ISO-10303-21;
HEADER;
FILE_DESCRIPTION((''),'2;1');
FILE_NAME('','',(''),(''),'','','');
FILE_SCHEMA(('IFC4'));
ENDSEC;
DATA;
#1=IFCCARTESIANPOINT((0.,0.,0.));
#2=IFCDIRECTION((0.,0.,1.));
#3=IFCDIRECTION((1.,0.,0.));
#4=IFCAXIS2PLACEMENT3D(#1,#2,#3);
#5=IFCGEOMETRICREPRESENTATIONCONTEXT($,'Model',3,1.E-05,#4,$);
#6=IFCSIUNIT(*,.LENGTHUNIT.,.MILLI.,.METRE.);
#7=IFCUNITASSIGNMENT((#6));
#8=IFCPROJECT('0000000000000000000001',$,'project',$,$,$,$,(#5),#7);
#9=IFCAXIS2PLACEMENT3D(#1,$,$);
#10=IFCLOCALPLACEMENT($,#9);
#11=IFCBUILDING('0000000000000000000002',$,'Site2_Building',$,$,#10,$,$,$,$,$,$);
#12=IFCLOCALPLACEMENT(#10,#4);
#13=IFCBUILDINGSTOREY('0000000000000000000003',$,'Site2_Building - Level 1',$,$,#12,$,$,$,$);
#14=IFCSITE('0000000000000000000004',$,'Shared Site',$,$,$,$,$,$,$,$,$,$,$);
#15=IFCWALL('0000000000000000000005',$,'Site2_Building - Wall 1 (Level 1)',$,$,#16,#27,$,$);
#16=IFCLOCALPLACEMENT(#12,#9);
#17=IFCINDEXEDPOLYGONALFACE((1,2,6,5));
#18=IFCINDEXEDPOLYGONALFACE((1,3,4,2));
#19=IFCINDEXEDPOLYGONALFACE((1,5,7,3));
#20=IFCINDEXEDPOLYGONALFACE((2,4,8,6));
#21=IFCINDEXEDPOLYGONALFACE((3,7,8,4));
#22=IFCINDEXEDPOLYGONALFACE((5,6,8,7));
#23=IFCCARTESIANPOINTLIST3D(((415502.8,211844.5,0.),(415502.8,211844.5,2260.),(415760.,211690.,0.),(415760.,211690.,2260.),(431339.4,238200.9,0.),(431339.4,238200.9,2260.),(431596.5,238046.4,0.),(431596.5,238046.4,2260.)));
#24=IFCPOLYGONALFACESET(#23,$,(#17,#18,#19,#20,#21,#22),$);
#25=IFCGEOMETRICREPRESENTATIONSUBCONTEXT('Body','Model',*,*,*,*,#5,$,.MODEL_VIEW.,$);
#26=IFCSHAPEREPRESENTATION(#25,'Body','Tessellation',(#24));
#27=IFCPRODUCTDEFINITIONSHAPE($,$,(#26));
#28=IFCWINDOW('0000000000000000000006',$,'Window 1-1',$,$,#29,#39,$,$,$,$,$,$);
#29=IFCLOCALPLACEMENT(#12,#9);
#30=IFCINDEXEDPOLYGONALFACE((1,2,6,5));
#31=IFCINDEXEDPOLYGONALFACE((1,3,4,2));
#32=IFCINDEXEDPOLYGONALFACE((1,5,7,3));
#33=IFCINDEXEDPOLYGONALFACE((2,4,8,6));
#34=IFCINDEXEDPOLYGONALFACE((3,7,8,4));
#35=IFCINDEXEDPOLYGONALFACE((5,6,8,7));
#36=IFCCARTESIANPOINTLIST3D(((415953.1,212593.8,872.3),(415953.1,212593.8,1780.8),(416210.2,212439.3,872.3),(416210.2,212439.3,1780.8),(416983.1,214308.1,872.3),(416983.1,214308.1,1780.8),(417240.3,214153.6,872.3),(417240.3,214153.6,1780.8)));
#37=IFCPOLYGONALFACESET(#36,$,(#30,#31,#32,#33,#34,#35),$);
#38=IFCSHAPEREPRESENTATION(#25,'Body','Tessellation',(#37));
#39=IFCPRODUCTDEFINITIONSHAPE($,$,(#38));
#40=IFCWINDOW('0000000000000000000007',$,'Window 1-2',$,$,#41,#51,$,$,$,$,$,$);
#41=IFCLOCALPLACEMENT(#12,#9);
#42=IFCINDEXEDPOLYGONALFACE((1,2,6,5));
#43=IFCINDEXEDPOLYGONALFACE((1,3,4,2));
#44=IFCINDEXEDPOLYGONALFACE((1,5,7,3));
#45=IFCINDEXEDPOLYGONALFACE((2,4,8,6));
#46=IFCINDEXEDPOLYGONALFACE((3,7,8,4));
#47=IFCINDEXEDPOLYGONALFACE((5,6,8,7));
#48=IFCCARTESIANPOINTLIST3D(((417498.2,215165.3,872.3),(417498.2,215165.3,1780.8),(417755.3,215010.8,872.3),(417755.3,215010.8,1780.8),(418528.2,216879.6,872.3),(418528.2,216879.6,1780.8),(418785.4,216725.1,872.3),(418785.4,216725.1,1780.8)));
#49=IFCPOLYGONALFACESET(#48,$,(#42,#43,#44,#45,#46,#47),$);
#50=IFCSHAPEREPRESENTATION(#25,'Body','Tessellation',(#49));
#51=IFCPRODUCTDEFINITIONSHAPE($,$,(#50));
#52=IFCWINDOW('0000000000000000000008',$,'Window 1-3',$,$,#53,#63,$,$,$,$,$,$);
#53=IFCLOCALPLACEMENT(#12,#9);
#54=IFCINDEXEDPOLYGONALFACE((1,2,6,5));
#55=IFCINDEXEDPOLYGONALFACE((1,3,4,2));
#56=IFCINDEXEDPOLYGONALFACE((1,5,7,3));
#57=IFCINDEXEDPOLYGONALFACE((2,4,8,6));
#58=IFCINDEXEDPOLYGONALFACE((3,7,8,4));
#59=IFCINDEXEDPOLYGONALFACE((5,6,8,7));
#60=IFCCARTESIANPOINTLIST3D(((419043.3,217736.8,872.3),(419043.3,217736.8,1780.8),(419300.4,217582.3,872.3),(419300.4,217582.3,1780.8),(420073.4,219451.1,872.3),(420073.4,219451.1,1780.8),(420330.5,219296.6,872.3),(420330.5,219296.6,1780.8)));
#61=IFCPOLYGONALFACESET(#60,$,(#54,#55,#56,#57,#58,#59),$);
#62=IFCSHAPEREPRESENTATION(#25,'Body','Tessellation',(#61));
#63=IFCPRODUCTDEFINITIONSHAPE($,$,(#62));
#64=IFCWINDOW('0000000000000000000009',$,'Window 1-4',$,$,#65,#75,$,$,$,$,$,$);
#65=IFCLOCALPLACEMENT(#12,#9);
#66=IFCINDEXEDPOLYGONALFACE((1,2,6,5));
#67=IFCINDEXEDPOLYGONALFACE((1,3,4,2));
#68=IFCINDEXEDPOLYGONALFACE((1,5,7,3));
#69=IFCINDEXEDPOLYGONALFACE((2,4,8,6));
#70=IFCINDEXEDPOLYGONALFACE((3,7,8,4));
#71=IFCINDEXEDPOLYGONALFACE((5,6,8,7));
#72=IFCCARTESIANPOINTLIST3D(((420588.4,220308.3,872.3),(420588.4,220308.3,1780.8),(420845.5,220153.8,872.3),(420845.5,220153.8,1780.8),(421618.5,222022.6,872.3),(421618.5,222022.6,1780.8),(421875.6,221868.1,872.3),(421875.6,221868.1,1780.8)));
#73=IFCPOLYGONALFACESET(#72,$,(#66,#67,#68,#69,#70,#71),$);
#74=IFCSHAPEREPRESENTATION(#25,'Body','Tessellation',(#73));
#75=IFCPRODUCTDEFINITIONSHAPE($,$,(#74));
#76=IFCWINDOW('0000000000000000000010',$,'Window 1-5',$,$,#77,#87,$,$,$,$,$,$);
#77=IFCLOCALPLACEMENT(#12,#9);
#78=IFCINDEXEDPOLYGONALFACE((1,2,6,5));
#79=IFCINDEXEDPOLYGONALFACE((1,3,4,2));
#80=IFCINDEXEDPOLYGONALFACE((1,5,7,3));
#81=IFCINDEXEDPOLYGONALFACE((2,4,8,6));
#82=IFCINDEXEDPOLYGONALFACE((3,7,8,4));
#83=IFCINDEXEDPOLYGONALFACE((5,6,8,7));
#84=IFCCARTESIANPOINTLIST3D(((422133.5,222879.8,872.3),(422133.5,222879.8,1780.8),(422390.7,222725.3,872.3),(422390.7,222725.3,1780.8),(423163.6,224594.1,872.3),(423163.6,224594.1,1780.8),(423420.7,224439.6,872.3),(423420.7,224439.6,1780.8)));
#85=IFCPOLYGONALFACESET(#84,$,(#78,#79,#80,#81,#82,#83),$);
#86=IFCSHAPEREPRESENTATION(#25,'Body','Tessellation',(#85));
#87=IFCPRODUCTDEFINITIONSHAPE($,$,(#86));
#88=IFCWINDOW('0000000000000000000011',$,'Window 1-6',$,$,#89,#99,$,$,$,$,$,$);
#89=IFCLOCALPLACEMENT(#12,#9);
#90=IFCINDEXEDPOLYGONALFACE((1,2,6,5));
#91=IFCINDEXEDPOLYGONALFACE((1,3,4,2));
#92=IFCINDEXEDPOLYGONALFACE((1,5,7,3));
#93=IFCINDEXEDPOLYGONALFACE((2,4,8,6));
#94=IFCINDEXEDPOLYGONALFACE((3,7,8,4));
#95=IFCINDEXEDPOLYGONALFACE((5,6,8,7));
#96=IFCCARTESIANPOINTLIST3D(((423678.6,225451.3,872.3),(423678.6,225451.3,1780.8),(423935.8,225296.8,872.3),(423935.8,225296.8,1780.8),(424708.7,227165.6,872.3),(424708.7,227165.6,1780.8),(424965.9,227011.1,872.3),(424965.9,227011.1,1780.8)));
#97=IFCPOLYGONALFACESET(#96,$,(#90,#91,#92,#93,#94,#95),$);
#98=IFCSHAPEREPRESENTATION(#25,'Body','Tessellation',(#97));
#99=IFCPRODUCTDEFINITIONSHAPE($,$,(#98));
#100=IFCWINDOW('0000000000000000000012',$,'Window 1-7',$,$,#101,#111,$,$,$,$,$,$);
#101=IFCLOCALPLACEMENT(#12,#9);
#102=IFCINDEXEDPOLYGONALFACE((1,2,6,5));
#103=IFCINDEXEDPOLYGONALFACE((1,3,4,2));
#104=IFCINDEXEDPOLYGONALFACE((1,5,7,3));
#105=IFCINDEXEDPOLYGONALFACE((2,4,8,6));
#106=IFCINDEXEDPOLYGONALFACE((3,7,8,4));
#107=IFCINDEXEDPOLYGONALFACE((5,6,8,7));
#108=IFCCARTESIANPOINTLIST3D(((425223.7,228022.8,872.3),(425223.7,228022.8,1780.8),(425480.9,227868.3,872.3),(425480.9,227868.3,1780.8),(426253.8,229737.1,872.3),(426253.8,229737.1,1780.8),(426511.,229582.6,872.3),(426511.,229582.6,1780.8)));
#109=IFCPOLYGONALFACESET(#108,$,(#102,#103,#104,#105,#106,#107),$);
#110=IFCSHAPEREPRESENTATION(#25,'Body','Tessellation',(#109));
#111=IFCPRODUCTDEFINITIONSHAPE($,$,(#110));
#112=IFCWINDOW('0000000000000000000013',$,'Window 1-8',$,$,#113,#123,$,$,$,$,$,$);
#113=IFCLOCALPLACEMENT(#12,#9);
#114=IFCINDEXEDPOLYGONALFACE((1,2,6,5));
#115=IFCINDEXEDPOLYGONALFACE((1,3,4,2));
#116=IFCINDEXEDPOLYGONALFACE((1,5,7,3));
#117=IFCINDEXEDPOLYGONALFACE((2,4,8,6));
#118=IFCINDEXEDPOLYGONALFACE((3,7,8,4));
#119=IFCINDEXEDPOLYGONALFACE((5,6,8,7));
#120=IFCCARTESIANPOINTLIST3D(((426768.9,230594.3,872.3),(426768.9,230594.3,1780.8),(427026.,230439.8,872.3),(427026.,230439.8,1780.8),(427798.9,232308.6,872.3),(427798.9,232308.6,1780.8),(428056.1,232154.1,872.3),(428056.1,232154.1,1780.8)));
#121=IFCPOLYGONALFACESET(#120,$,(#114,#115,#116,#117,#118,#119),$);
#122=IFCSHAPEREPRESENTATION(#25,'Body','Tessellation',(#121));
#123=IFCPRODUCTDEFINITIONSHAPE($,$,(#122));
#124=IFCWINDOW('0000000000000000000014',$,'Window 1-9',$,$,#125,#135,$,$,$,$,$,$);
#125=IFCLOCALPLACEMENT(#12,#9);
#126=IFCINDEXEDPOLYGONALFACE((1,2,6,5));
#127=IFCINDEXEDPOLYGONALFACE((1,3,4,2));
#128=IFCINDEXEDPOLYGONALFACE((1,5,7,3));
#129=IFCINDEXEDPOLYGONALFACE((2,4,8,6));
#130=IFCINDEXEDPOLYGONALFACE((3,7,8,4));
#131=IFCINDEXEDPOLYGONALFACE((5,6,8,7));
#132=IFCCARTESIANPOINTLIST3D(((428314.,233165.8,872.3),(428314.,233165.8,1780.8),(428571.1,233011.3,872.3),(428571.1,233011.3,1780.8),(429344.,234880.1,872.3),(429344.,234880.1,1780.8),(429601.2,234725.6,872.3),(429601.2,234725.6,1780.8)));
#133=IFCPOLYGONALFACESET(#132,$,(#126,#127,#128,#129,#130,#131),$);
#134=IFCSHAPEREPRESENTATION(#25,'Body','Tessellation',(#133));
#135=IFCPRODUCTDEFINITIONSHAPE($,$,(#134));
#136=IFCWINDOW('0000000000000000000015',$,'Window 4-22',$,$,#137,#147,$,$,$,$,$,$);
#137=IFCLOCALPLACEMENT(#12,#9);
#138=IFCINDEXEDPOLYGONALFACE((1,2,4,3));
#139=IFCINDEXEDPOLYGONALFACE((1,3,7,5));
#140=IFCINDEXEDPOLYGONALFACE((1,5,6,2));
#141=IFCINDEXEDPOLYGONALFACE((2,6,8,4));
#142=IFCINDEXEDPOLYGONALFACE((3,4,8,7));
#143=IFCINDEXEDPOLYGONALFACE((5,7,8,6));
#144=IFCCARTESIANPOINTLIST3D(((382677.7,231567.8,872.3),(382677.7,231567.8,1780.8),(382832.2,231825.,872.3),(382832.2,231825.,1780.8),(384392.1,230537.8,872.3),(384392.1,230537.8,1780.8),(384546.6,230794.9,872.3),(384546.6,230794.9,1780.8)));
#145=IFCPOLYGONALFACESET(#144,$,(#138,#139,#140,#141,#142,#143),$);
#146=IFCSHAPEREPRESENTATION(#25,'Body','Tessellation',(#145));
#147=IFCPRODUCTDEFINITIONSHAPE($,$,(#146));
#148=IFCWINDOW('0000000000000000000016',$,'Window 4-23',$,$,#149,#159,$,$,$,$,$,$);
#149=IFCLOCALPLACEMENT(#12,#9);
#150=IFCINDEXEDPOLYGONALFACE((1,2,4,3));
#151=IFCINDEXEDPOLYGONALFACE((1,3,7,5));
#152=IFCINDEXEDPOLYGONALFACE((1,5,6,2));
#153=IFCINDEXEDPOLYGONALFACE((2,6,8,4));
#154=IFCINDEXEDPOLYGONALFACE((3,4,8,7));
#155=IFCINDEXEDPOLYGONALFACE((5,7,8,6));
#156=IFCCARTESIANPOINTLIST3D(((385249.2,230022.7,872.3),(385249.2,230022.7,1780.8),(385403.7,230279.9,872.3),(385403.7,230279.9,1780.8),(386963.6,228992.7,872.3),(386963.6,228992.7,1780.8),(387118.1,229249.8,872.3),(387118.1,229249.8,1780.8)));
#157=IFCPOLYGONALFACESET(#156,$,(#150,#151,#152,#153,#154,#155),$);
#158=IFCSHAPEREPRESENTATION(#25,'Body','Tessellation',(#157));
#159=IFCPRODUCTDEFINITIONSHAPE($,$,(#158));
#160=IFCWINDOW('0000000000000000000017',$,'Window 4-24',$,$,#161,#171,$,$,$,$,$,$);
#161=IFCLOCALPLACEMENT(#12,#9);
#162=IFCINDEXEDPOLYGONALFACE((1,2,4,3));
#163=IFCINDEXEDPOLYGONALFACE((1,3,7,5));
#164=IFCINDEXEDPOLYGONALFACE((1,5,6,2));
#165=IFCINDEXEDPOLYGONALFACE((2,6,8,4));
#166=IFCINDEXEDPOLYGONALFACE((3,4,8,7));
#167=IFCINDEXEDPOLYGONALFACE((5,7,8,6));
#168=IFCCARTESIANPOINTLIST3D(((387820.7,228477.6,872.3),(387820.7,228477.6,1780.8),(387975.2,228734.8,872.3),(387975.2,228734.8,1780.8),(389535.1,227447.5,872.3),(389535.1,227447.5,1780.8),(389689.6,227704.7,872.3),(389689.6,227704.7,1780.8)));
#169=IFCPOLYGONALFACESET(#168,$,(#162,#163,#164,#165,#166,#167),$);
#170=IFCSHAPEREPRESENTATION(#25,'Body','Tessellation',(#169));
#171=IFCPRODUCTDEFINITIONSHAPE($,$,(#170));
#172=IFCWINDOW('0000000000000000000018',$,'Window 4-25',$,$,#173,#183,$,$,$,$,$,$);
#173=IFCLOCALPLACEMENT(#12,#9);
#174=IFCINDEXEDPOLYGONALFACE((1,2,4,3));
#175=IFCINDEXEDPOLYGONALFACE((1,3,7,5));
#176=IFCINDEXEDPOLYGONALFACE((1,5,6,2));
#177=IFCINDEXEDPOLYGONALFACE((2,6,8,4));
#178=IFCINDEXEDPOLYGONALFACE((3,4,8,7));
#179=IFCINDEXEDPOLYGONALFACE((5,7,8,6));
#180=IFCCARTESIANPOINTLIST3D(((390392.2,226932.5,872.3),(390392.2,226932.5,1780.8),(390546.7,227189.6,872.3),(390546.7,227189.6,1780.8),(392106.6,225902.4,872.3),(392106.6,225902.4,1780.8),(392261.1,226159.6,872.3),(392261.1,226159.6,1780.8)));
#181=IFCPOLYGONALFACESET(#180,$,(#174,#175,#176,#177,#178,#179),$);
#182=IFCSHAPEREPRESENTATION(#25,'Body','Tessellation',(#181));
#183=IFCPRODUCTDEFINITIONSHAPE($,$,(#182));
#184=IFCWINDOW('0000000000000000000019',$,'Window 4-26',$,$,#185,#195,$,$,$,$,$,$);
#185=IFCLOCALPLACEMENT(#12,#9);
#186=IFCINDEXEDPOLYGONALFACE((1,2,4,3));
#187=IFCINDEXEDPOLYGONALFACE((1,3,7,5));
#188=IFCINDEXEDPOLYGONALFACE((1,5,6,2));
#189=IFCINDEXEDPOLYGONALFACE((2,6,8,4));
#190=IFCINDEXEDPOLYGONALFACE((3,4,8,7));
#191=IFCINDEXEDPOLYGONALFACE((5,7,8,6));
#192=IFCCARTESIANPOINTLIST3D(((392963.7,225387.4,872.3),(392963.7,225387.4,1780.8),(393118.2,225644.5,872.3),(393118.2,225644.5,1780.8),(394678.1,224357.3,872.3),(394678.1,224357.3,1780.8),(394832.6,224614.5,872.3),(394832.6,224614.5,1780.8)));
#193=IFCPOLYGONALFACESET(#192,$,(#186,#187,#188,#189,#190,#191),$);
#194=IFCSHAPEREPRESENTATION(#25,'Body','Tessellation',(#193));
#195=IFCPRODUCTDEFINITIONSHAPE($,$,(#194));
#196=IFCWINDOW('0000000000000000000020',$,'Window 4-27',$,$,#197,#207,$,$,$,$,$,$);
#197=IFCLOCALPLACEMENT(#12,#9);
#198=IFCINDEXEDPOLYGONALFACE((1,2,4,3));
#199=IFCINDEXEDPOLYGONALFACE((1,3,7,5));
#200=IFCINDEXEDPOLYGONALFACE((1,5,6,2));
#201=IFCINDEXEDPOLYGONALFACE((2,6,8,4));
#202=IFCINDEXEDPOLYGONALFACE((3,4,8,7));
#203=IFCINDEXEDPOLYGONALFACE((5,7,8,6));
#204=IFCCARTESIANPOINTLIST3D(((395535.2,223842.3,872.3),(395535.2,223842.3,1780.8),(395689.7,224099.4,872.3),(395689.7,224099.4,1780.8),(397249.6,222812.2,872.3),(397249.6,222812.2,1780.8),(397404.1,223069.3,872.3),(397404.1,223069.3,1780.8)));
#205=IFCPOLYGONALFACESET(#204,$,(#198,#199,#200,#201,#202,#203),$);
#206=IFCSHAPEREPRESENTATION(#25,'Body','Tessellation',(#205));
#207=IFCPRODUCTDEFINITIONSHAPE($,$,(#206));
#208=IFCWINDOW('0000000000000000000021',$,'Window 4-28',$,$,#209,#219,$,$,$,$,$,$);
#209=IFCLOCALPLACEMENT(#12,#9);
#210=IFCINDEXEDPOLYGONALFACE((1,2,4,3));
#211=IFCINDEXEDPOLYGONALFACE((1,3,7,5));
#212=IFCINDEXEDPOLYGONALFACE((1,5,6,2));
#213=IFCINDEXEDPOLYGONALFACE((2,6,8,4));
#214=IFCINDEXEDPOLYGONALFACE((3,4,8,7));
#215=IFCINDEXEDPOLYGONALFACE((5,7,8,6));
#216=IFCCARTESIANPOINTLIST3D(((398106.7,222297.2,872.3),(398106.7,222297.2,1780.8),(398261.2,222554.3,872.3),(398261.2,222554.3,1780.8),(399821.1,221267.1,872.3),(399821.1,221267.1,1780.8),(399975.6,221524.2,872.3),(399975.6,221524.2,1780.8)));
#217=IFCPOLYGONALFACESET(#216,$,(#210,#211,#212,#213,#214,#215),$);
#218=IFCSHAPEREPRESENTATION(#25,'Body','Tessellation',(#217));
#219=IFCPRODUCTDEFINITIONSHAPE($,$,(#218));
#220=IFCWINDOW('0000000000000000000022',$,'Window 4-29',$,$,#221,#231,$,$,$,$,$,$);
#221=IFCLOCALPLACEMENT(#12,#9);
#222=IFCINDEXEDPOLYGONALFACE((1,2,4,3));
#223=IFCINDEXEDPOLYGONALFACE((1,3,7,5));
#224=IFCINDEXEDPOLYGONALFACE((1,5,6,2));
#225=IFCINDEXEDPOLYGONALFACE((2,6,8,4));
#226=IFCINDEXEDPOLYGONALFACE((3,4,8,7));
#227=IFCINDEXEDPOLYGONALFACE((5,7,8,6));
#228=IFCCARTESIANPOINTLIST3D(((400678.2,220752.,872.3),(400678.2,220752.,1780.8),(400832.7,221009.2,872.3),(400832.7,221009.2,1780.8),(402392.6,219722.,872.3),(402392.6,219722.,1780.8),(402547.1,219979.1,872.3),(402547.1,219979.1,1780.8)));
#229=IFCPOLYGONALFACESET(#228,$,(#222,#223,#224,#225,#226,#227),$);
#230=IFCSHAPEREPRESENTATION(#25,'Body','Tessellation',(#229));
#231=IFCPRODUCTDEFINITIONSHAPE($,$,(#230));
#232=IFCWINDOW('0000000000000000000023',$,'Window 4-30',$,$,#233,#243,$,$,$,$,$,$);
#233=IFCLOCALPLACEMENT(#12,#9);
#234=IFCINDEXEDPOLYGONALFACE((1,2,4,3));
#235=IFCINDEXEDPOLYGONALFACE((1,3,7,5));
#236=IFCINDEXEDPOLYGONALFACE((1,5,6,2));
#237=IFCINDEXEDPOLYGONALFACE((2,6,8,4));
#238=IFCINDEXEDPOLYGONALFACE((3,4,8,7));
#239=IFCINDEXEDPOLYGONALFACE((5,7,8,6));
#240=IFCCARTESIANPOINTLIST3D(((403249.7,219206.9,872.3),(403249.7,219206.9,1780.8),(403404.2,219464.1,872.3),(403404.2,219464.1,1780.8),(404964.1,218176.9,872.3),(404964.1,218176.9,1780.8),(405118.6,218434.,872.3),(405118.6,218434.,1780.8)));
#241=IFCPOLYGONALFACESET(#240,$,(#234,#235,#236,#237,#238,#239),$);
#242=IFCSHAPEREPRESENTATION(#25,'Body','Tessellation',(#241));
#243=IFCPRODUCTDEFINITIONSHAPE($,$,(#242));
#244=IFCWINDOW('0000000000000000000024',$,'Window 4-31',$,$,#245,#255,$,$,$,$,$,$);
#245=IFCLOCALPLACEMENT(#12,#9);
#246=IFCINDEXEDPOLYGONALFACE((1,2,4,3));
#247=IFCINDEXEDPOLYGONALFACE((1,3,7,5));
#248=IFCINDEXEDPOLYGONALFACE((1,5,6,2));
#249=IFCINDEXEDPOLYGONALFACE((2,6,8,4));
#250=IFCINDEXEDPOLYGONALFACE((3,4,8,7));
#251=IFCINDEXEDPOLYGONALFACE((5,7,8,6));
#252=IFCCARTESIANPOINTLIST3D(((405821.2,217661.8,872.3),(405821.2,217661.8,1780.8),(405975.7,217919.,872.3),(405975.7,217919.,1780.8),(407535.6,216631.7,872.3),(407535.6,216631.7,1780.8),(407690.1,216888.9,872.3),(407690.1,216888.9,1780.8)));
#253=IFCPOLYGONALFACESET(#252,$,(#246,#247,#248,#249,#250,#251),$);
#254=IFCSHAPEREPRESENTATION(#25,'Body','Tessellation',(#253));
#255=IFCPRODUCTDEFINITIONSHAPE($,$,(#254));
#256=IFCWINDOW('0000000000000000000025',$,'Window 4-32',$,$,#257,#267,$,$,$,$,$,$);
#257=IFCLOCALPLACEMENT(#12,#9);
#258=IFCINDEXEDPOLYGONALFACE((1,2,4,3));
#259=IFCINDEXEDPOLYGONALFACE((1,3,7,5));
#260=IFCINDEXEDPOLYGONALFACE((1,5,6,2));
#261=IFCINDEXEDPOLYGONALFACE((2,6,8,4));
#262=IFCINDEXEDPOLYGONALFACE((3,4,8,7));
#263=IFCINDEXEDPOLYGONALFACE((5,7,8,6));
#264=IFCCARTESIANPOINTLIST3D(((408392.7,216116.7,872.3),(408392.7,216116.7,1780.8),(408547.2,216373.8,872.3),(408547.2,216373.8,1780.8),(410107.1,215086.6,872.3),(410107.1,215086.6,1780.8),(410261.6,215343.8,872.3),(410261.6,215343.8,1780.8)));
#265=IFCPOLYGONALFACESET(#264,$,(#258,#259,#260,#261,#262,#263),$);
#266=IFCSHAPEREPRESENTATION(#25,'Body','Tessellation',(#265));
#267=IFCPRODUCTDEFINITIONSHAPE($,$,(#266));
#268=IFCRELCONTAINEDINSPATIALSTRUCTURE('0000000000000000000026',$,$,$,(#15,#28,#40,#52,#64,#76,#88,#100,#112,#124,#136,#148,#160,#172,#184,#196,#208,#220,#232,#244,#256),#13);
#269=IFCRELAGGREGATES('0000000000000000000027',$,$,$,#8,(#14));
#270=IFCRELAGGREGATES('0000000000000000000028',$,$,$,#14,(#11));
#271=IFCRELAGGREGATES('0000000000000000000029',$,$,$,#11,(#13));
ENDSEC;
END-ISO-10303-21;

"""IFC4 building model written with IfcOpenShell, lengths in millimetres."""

from ifc_helpers import new_model, si_unit, frame, origin, origin_with_axes, place, context, subcontext, project, spatial, indexed_curve, outline, extrude, element, save


model = new_model("IFC4")

# Units and contexts
model_context = context("Model", 3, precision=1e-05, world=origin_with_axes())
body_context = subcontext(model_context, "Body", "Model", "MODEL_VIEW")
ifc_project = project(units=[si_unit("LENGTHUNIT", "METRE", prefix="MILLI")], contexts=[model_context])

# Site, building, storey
site = spatial("IfcSite", under=ifc_project, Name="Shared Site")
building_placement = place(None, origin())
building = spatial("IfcBuilding", under=site, at=building_placement, Name="Site2_Building")
storey_placement = place(building_placement, origin_with_axes())
storey = spatial("IfcBuildingStorey", under=building, at=storey_placement, Name="Site2_Building - Level 1")

# Wall
wall_placement = place(storey_placement, frame((415760.0, 211690.0, 0.0), z_axis=(0.0, 0.0, 1.0), x_axis=(0.515038, 0.857167, 0.0)))
element("IfcWall", 1, at=wall_placement, inside=storey, Name="Site2_Building - Wall 1 (Level 1)", context=body_context, shape_type="SweptSolid", body=[
    extrude(outline(indexed_curve([(0.0, 0.0), (0.0, 300.0), (30748.2, 300.0), (30748.2, 0.0), (0.0, 0.0)], self_intersect=False)), origin_with_axes(), (0.0, 0.0, 1.0), 2260.0),
])

# Windows
for number, where, z_axis, x_axis, name in (
    (2, (416210.2, 212439.3, 872.3), (0.0, 0.0, 1.0), (0.515038, 0.857167, 0.0), "Window 1-1"),
    (3, (417755.3, 215010.8, 872.3), (0.0, 0.0, 1.0), (0.515038, 0.857167, 0.0), "Window 1-2"),
    (4, (419300.4, 217582.3, 872.3), (0.0, 0.0, 1.0), (0.515038, 0.857167, 0.0), "Window 1-3"),
    (5, (420845.5, 220153.8, 872.3), (0.0, 0.0, 1.0), (0.515038, 0.857167, 0.0), "Window 1-4"),
    (6, (422390.7, 222725.3, 872.3), (0.0, 0.0, 1.0), (0.515038, 0.857167, 0.0), "Window 1-5"),
    (7, (423935.8, 225296.8, 872.3), (0.0, 0.0, 1.0), (0.515038, 0.857167, 0.0), "Window 1-6"),
    (8, (425480.9, 227868.3, 872.3), (0.0, 0.0, 1.0), (0.515038, 0.857167, 0.0), "Window 1-7"),
    (9, (427026.0, 230439.8, 872.3), (0.0, 0.0, 1.0), (0.515038, 0.857167, 0.0), "Window 1-8"),
    (10, (428571.1, 233011.3, 872.3), (0.0, 0.0, 1.0), (0.515038, 0.857167, 0.0), "Window 1-9"),
    (11, (382677.7, 231567.8, 872.3), (0.0, 0.0, 1.0), (0.857167, -0.515038, 0.0), "Window 4-22"),
    (12, (385249.2, 230022.7, 872.3), (0.0, 0.0, 1.0), (0.857167, -0.515038, 0.0), "Window 4-23"),
    (13, (387820.7, 228477.6, 872.3), (0.0, 0.0, 1.0), (0.857167, -0.515038, 0.0), "Window 4-24"),
    (14, (390392.2, 226932.5, 872.3), (0.0, 0.0, 1.0), (0.857167, -0.515038, 0.0), "Window 4-25"),
    (15, (392963.7, 225387.4, 872.3), (0.0, 0.0, 1.0), (0.857167, -0.515038, 0.0), "Window 4-26"),
    (16, (395535.2, 223842.3, 872.3), (0.0, 0.0, 1.0), (0.857167, -0.515038, 0.0), "Window 4-27"),
    (17, (398106.7, 222297.2, 872.3), (0.0, 0.0, 1.0), (0.857167, -0.515038, 0.0), "Window 4-28"),
    (18, (400678.2, 220752.0, 872.3), (0.0, 0.0, 1.0), (0.857167, -0.515038, 0.0), "Window 4-29"),
    (19, (403249.7, 219206.9, 872.3), (0.0, 0.0, 1.0), (0.857167, -0.515038, 0.0), "Window 4-30"),
    (20, (405821.2, 217661.8, 872.3), (0.0, 0.0, 1.0), (0.857167, -0.515038, 0.0), "Window 4-31"),
    (21, (408392.7, 216116.7, 872.3), (0.0, 0.0, 1.0), (0.857167, -0.515038, 0.0), "Window 4-32"),
):
    element("IfcWindow", number, at=place(storey_placement, frame(where, z_axis=z_axis, x_axis=x_axis)), inside=storey, Name=name, context=body_context, shape_type="SweptSolid", body=[
        extrude(outline(indexed_curve([(0.0, 0.0), (0.0, 300.0), (2000.0, 300.0), (2000.0, 0.0), (0.0, 0.0)], self_intersect=False)), origin_with_axes(), (0.0, 0.0, 1.0), 908.6),
    ])

save(model, "model.ifc")
